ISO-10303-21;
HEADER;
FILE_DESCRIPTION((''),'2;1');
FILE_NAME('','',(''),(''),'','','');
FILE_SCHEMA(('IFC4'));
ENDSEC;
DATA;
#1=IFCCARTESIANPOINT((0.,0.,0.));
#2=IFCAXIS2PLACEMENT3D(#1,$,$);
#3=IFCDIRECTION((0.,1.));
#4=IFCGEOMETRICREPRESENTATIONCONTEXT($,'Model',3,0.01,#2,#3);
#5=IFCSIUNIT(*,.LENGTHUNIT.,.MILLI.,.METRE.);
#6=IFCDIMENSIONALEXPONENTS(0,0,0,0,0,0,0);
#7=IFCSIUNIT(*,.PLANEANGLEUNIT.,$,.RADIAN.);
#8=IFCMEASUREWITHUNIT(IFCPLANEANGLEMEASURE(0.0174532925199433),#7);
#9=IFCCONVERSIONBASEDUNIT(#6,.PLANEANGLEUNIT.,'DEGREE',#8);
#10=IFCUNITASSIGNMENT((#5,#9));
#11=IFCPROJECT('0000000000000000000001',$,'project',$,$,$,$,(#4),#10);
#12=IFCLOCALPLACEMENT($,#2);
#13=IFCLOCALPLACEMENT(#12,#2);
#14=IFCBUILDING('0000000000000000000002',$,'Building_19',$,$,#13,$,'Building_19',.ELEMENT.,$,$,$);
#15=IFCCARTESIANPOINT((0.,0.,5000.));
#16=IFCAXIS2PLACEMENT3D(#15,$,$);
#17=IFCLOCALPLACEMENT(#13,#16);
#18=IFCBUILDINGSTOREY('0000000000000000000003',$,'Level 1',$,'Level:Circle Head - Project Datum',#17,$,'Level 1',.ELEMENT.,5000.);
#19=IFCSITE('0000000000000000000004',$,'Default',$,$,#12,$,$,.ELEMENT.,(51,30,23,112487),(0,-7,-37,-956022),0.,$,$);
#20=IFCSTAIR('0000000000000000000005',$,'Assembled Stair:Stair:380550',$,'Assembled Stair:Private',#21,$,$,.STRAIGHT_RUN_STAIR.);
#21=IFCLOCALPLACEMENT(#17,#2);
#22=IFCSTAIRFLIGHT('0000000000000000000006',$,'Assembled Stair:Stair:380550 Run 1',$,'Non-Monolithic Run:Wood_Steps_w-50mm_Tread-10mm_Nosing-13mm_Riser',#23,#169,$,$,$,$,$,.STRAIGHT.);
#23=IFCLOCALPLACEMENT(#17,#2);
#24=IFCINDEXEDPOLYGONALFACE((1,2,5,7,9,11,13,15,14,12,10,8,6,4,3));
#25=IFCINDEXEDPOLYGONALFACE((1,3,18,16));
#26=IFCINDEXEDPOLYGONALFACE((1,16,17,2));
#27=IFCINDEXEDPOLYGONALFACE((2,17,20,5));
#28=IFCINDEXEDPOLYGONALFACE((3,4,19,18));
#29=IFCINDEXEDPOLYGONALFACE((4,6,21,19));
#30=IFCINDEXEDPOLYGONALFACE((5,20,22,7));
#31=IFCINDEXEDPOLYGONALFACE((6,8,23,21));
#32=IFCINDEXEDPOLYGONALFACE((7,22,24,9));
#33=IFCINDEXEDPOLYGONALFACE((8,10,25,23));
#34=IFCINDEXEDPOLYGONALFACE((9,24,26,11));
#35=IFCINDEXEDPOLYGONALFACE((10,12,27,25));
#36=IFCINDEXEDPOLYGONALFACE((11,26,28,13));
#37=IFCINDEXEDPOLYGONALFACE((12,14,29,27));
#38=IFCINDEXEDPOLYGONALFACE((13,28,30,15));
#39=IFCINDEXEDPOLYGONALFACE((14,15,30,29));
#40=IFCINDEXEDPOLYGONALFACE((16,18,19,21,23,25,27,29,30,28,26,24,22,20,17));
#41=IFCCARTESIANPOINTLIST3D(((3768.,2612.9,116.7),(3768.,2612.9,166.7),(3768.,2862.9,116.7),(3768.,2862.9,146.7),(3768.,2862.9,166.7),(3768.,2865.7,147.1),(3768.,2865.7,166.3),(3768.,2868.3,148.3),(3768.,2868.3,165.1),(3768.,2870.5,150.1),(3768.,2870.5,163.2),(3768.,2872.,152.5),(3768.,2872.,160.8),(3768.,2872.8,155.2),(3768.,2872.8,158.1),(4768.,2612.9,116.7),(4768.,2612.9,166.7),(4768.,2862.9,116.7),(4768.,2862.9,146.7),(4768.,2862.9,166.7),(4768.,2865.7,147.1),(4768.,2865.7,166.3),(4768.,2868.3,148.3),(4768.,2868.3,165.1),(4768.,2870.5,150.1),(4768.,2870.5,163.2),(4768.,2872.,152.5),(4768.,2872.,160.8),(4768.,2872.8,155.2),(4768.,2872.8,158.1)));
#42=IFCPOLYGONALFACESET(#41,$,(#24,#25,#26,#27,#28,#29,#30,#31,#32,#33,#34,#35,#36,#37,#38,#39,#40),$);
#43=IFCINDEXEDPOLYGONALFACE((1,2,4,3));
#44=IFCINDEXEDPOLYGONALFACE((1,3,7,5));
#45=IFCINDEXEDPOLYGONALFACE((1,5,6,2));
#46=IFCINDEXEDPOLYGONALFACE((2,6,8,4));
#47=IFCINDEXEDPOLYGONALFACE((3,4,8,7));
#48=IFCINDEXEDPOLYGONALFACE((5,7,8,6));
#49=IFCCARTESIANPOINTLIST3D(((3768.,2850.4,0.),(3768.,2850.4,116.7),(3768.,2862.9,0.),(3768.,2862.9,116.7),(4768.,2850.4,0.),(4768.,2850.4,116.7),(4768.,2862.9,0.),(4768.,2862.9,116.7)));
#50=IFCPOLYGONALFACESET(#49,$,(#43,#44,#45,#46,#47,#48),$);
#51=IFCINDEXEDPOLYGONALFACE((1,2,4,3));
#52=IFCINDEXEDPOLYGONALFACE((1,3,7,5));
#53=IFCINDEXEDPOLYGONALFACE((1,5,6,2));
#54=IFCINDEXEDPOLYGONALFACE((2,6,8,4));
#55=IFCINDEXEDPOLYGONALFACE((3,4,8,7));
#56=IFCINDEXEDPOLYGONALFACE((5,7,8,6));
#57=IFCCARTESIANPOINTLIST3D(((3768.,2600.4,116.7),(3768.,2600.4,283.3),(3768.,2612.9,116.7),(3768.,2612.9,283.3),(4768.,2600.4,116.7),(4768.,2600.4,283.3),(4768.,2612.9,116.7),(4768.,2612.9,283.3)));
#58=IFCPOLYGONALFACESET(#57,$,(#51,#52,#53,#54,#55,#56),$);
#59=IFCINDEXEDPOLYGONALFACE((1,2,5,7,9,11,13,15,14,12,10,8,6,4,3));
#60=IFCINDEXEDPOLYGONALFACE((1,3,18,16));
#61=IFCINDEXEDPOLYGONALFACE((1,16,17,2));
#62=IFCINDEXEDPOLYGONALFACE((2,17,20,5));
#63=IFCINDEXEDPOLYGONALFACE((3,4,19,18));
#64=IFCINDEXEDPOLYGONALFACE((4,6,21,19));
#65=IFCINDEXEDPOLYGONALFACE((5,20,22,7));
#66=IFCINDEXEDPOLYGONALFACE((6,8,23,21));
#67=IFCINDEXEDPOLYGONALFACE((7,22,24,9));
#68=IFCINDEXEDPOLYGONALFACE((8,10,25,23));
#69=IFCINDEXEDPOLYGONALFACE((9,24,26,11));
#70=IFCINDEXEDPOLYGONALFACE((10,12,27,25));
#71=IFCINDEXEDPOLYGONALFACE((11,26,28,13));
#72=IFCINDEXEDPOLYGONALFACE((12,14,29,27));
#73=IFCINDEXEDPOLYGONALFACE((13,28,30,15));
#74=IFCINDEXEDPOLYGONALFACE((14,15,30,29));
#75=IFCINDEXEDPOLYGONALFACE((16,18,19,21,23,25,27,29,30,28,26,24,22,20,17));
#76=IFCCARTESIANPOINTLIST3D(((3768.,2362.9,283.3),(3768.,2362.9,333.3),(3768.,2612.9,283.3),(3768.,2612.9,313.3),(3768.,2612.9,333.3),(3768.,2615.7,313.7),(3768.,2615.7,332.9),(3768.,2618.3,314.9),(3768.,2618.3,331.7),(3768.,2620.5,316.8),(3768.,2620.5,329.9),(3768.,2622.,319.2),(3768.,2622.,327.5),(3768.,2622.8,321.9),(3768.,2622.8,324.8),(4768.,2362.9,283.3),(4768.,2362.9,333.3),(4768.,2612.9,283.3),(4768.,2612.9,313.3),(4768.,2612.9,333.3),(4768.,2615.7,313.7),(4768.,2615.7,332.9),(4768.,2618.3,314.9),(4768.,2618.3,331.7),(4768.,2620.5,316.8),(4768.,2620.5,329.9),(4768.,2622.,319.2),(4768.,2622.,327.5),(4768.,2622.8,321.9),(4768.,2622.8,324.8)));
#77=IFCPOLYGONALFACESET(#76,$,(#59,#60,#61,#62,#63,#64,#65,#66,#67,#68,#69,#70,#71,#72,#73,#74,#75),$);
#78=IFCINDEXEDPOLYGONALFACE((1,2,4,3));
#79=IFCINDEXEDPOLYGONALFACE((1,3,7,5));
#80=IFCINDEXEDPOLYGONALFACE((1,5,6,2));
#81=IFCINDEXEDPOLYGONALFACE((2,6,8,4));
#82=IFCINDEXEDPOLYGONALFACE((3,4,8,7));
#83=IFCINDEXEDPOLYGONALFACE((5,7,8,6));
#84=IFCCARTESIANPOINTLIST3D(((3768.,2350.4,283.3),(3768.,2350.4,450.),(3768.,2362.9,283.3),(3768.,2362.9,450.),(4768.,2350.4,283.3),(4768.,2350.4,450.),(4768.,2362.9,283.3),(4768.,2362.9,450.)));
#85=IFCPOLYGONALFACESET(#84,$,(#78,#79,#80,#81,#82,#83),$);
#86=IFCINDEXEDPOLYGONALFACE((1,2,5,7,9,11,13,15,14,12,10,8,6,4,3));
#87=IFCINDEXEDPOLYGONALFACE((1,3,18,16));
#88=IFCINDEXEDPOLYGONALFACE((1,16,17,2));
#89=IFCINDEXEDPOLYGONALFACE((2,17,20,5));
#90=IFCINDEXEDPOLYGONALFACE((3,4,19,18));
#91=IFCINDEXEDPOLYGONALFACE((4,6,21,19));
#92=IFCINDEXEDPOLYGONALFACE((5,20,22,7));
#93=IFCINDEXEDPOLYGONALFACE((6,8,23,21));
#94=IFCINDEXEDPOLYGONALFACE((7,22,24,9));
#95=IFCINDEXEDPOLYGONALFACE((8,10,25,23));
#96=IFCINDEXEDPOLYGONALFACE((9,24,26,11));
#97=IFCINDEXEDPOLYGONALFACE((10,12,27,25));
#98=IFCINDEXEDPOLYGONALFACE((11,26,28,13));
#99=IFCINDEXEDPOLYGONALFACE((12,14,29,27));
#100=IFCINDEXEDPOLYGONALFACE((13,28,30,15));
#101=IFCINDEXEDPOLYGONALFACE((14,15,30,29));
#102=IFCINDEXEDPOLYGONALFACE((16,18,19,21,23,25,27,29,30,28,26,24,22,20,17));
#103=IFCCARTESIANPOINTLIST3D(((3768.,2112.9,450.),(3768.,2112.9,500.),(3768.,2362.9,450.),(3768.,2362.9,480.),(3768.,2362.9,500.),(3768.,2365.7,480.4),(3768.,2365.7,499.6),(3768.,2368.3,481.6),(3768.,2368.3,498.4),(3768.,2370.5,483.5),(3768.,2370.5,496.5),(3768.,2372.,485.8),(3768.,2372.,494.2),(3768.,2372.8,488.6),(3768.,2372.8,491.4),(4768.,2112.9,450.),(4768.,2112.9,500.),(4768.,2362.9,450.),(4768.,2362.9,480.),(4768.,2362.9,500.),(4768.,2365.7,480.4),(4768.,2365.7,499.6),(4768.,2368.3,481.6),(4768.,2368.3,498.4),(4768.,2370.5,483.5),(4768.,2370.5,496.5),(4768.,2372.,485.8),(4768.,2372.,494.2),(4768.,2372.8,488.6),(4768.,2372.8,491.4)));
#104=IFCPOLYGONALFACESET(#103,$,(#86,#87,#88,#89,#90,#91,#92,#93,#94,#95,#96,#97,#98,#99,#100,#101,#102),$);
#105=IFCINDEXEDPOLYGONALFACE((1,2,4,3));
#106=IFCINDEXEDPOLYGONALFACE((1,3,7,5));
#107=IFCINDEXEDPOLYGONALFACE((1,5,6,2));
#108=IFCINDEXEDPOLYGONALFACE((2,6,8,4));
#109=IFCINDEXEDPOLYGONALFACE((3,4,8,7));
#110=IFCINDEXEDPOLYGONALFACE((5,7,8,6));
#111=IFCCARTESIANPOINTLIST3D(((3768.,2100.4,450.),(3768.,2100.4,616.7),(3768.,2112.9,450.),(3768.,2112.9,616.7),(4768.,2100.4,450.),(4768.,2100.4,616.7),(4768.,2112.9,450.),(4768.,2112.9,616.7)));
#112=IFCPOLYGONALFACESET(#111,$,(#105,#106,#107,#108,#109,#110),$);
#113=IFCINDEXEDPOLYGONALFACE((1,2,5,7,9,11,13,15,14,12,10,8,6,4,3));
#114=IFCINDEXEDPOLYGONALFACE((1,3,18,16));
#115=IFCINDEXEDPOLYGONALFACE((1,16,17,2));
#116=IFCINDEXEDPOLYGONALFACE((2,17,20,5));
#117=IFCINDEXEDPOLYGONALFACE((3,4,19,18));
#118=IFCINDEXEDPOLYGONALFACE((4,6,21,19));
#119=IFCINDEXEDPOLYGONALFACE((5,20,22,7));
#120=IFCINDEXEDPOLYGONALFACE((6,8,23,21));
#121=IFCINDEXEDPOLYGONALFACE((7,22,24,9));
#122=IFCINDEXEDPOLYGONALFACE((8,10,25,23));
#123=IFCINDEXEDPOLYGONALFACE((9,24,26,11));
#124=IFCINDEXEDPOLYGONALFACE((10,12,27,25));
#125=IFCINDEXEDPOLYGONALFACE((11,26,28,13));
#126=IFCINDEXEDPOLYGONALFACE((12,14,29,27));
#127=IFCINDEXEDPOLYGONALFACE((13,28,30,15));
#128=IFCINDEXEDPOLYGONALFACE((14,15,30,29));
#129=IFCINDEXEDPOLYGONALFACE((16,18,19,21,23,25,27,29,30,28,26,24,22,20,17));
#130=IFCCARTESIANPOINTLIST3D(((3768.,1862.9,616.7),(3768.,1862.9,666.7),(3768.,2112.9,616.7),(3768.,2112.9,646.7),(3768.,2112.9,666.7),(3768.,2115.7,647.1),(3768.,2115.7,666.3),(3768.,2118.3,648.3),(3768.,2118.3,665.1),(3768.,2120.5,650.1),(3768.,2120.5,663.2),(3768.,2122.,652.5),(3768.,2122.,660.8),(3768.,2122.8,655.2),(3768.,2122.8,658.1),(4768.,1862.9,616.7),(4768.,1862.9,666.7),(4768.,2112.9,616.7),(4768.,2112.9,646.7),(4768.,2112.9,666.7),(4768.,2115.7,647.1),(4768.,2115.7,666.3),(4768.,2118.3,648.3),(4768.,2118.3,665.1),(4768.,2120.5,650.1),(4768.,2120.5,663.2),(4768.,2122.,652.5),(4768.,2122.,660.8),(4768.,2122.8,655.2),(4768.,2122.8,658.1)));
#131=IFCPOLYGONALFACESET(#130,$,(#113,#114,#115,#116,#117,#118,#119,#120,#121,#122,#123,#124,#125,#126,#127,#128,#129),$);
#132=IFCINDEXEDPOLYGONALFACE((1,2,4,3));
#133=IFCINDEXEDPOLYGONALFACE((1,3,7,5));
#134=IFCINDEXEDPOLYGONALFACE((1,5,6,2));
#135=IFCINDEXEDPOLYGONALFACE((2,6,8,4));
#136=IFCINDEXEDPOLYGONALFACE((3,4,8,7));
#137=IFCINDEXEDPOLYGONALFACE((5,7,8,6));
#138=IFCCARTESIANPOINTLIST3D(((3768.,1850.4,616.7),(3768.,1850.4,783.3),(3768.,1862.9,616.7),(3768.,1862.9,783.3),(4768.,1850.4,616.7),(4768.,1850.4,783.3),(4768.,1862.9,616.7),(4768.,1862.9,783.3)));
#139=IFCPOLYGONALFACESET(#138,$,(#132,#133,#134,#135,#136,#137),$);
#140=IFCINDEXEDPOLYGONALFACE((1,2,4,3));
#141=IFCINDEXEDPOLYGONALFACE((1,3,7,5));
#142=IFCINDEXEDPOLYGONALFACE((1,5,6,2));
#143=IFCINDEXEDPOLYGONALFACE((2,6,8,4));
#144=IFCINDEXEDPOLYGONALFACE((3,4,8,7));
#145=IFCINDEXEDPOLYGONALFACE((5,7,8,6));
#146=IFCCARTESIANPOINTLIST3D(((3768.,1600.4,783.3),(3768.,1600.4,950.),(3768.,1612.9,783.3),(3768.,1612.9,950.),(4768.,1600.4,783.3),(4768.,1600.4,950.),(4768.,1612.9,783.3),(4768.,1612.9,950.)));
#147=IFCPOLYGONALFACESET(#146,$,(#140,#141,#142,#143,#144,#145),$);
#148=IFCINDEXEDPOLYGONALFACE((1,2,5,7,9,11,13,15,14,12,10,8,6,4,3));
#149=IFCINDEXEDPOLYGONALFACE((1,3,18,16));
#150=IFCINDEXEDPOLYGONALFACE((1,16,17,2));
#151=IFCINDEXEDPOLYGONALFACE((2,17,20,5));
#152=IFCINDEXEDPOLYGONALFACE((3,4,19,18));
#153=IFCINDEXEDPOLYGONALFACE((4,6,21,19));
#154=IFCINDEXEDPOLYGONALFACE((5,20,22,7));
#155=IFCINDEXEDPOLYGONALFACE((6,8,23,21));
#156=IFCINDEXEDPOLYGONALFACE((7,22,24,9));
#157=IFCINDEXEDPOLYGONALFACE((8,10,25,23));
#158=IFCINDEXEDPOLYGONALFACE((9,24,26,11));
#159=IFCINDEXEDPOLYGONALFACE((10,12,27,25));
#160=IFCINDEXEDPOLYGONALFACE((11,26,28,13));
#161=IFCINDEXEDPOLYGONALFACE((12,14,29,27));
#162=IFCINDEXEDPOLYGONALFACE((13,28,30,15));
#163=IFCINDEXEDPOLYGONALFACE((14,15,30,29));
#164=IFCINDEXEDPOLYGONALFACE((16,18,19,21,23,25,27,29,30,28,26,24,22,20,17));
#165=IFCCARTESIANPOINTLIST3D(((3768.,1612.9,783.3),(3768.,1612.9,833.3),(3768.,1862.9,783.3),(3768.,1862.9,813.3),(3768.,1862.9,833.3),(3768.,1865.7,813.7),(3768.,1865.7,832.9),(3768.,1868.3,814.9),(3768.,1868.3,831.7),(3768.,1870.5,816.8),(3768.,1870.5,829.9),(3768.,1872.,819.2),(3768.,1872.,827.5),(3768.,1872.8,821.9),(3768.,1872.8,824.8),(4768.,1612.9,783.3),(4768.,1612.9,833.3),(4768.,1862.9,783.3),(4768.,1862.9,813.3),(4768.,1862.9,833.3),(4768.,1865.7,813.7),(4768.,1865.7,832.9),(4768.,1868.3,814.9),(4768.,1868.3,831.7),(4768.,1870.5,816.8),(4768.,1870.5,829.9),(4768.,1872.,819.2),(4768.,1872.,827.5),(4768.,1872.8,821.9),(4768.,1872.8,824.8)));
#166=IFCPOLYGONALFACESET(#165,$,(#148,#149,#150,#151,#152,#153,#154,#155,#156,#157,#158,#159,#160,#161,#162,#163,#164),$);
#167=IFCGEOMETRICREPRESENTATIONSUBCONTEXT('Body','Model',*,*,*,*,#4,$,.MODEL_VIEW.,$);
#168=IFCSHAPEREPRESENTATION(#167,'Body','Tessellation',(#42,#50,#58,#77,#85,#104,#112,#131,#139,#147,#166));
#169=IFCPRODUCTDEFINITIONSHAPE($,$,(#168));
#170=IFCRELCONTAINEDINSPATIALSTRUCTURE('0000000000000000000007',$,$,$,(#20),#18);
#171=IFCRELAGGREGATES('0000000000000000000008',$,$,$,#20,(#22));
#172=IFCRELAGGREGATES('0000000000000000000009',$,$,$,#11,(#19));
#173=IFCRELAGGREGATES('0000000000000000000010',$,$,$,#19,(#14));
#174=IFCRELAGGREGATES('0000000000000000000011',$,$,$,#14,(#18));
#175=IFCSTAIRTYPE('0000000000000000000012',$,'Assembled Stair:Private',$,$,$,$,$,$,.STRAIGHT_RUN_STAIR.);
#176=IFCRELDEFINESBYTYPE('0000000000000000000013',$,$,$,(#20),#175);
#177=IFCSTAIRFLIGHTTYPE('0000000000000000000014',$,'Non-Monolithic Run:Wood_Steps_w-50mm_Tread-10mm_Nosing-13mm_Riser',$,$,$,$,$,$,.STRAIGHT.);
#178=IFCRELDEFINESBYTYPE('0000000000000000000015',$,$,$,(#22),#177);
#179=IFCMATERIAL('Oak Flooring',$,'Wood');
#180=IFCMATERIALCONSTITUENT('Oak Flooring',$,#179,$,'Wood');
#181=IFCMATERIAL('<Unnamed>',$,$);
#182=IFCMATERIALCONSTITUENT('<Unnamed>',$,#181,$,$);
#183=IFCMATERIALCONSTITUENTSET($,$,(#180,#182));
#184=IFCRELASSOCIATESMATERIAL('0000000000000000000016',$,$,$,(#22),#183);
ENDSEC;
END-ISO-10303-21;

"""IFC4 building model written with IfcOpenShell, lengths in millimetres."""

from ifc_helpers import new_model, entity, si_unit, converted_unit, direction, frame, origin, place, context, subcontext, project, spatial, line, arc, indexed_curve, outline, extrude, material, constituent, constituent_set, type_object, element, aggregate, save


model = new_model("IFC4")

# Units and contexts
model_context = context("Model", 3, precision=0.01, world=origin(), true_north=direction((0.0, 1.0)))
body_context = subcontext(model_context, "Body", "Model", "MODEL_VIEW")
ifc_project = project(units=[si_unit("LENGTHUNIT", "METRE", prefix="MILLI"), converted_unit("PLANEANGLEUNIT", "DEGREE", entity("IfcPlaneAngleMeasure", 0.0174532925199433), si_unit("PLANEANGLEUNIT", "RADIAN"), dimensions=[0, 0, 0, 0, 0, 0, 0])], contexts=[model_context])

# Site, building, storey
site_placement = place(None, origin())
site = spatial("IfcSite", under=ifc_project, at=site_placement, Name="Default", CompositionType="ELEMENT", RefLatitude=(51, 30, 23, 112487), RefLongitude=(0, -7, -37, -956022), RefElevation=0.0)
building_placement = place(site_placement, origin())
building = spatial("IfcBuilding", under=site, at=building_placement, Name="Building_19", LongName="Building_19", CompositionType="ELEMENT")
storey_placement = place(building_placement, frame((0.0, 0.0, 5000.0)))
storey = spatial("IfcBuildingStorey", under=building, at=storey_placement, Name="Level 1", ObjectType="Level:Circle Head - Project Datum", LongName="Level 1", CompositionType="ELEMENT", Elevation=5000.0)

# Stair
stair_type = type_object("IfcStairType", Name="Assembled Stair:Private", PredefinedType="STRAIGHT_RUN_STAIR")
ifc_material_1 = material(Name="<Unnamed>")
stair_1_placement = place(storey_placement, origin())
stair_1 = element("IfcStair", 1, at=stair_1_placement, inside=storey, type_object=stair_type, Name="Assembled Stair:Stair:380550", ObjectType="Assembled Stair:Private", PredefinedType="STRAIGHT_RUN_STAIR")

# Stair flight
ifc_material_2 = material(Name="Oak Flooring", Category="Wood")
stair_flight_type = type_object("IfcStairFlightType", Name="Non-Monolithic Run:Wood_Steps_w-50mm_Tread-10mm_Nosing-13mm_Riser", PredefinedType="STRAIGHT")
ifc_constituent_1 = constituent(ifc_material_2, Name="Oak Flooring", Category="Wood")
ifc_constituent_2 = constituent(ifc_material_1, Name="<Unnamed>")
ifc_constituent_set_1 = constituent_set(constituents=[ifc_constituent_1, ifc_constituent_2])
stair_flight_1_placement = place(stair_1_placement, origin())
stair_flight_1 = element("IfcStairFlight", 2, at=stair_flight_1_placement, type_object=stair_flight_type, material=ifc_constituent_set_1, Name="Assembled Stair:Stair:380550 Run 1", ObjectType="Non-Monolithic Run:Wood_Steps_w-50mm_Tread-10mm_Nosing-13mm_Riser", PredefinedType="STRAIGHT", context=body_context, shape_type="SweptSolid", body=[
    extrude(outline(indexed_curve([(-24.0, -150.0), (26.0, -150.0), (26.0, 100.0), (-4.0, 100.0), (-14.0, 110.0), (-24.0, 100.0)], segments=[line(1, 2, 3, 4), arc(4, 5, 6), line(6, 1)], self_intersect=False)), frame((3768.0, 2762.9, 142.7), z_axis=(1.0, 0.0, 0.0), x_axis=(0.0, 0.0, -1.0)), (0.0, 0.0, 1.0), 1000.0),
    extrude(outline(indexed_curve([(-500.0, -6.3), (500.0, -6.3), (500.0, 6.2), (-500.0, 6.2), (-500.0, -6.3)], self_intersect=False)), frame((4268.0, 2856.6, 0.0)), (0.0, 0.0, 1.0), 116.7),
    extrude(outline(indexed_curve([(-500.0, -6.3), (500.0, -6.3), (500.0, 6.2), (-500.0, 6.2), (-500.0, -6.3)], self_intersect=False)), frame((4268.0, 2606.6, 116.7)), (0.0, 0.0, 1.0), 166.7),
    extrude(outline(indexed_curve([(-24.0, -150.0), (26.0, -150.0), (26.0, 100.0), (-4.0, 100.0), (-14.0, 110.0), (-24.0, 100.0)], segments=[line(1, 2, 3, 4), arc(4, 5, 6), line(6, 1)], self_intersect=False)), frame((3768.0, 2512.9, 309.3), z_axis=(1.0, 0.0, 0.0), x_axis=(0.0, 0.0, -1.0)), (0.0, 0.0, 1.0), 1000.0),
    extrude(outline(indexed_curve([(-500.0, -6.2), (500.0, -6.2), (500.0, 6.2), (-500.0, 6.2), (-500.0, -6.2)], self_intersect=False)), frame((4268.0, 2356.6, 283.3)), (0.0, 0.0, 1.0), 166.7),
    extrude(outline(indexed_curve([(-24.0, -150.0), (26.0, -150.0), (26.0, 100.0), (-4.0, 100.0), (-14.0, 110.0), (-24.0, 100.0)], segments=[line(1, 2, 3, 4), arc(4, 5, 6), line(6, 1)], self_intersect=False)), frame((3768.0, 2262.9, 476.0), z_axis=(1.0, 0.0, 0.0), x_axis=(0.0, 0.0, -1.0)), (0.0, 0.0, 1.0), 1000.0),
    extrude(outline(indexed_curve([(-500.0, -6.2), (500.0, -6.2), (500.0, 6.3), (-500.0, 6.3), (-500.0, -6.2)], self_intersect=False)), frame((4268.0, 2106.6, 450.0)), (0.0, 0.0, 1.0), 166.7),
    extrude(outline(indexed_curve([(-24.0, -150.0), (26.0, -150.0), (26.0, 100.0), (-4.0, 100.0), (-14.0, 110.0), (-24.0, 100.0)], segments=[line(1, 2, 3, 4), arc(4, 5, 6), line(6, 1)], self_intersect=False)), frame((3768.0, 2012.9, 642.7), z_axis=(1.0, 0.0, 0.0), x_axis=(0.0, 0.0, -1.0)), (0.0, 0.0, 1.0), 1000.0),
    extrude(outline(indexed_curve([(-500.0, -6.2), (500.0, -6.2), (500.0, 6.2), (-500.0, 6.2), (-500.0, -6.2)], self_intersect=False)), frame((4268.0, 1856.6, 616.7)), (0.0, 0.0, 1.0), 166.7),
    extrude(outline(indexed_curve([(-500.0, -6.2), (500.0, -6.2), (500.0, 6.2), (-500.0, 6.2), (-500.0, -6.2)], self_intersect=False)), frame((4268.0, 1606.6, 783.3)), (0.0, 0.0, 1.0), 166.7),
    extrude(outline(indexed_curve([(-24.0, -150.0), (26.0, -150.0), (26.0, 100.0), (-4.0, 100.0), (-14.0, 110.0), (-24.0, 100.0)], segments=[line(1, 2, 3, 4), arc(4, 5, 6), line(6, 1)], self_intersect=False)), frame((3768.0, 1762.9, 809.3), z_axis=(1.0, 0.0, 0.0), x_axis=(0.0, 0.0, -1.0)), (0.0, 0.0, 1.0), 1000.0),
])

aggregate(stair_1, [stair_flight_1])

save(model, "model.ifc")
